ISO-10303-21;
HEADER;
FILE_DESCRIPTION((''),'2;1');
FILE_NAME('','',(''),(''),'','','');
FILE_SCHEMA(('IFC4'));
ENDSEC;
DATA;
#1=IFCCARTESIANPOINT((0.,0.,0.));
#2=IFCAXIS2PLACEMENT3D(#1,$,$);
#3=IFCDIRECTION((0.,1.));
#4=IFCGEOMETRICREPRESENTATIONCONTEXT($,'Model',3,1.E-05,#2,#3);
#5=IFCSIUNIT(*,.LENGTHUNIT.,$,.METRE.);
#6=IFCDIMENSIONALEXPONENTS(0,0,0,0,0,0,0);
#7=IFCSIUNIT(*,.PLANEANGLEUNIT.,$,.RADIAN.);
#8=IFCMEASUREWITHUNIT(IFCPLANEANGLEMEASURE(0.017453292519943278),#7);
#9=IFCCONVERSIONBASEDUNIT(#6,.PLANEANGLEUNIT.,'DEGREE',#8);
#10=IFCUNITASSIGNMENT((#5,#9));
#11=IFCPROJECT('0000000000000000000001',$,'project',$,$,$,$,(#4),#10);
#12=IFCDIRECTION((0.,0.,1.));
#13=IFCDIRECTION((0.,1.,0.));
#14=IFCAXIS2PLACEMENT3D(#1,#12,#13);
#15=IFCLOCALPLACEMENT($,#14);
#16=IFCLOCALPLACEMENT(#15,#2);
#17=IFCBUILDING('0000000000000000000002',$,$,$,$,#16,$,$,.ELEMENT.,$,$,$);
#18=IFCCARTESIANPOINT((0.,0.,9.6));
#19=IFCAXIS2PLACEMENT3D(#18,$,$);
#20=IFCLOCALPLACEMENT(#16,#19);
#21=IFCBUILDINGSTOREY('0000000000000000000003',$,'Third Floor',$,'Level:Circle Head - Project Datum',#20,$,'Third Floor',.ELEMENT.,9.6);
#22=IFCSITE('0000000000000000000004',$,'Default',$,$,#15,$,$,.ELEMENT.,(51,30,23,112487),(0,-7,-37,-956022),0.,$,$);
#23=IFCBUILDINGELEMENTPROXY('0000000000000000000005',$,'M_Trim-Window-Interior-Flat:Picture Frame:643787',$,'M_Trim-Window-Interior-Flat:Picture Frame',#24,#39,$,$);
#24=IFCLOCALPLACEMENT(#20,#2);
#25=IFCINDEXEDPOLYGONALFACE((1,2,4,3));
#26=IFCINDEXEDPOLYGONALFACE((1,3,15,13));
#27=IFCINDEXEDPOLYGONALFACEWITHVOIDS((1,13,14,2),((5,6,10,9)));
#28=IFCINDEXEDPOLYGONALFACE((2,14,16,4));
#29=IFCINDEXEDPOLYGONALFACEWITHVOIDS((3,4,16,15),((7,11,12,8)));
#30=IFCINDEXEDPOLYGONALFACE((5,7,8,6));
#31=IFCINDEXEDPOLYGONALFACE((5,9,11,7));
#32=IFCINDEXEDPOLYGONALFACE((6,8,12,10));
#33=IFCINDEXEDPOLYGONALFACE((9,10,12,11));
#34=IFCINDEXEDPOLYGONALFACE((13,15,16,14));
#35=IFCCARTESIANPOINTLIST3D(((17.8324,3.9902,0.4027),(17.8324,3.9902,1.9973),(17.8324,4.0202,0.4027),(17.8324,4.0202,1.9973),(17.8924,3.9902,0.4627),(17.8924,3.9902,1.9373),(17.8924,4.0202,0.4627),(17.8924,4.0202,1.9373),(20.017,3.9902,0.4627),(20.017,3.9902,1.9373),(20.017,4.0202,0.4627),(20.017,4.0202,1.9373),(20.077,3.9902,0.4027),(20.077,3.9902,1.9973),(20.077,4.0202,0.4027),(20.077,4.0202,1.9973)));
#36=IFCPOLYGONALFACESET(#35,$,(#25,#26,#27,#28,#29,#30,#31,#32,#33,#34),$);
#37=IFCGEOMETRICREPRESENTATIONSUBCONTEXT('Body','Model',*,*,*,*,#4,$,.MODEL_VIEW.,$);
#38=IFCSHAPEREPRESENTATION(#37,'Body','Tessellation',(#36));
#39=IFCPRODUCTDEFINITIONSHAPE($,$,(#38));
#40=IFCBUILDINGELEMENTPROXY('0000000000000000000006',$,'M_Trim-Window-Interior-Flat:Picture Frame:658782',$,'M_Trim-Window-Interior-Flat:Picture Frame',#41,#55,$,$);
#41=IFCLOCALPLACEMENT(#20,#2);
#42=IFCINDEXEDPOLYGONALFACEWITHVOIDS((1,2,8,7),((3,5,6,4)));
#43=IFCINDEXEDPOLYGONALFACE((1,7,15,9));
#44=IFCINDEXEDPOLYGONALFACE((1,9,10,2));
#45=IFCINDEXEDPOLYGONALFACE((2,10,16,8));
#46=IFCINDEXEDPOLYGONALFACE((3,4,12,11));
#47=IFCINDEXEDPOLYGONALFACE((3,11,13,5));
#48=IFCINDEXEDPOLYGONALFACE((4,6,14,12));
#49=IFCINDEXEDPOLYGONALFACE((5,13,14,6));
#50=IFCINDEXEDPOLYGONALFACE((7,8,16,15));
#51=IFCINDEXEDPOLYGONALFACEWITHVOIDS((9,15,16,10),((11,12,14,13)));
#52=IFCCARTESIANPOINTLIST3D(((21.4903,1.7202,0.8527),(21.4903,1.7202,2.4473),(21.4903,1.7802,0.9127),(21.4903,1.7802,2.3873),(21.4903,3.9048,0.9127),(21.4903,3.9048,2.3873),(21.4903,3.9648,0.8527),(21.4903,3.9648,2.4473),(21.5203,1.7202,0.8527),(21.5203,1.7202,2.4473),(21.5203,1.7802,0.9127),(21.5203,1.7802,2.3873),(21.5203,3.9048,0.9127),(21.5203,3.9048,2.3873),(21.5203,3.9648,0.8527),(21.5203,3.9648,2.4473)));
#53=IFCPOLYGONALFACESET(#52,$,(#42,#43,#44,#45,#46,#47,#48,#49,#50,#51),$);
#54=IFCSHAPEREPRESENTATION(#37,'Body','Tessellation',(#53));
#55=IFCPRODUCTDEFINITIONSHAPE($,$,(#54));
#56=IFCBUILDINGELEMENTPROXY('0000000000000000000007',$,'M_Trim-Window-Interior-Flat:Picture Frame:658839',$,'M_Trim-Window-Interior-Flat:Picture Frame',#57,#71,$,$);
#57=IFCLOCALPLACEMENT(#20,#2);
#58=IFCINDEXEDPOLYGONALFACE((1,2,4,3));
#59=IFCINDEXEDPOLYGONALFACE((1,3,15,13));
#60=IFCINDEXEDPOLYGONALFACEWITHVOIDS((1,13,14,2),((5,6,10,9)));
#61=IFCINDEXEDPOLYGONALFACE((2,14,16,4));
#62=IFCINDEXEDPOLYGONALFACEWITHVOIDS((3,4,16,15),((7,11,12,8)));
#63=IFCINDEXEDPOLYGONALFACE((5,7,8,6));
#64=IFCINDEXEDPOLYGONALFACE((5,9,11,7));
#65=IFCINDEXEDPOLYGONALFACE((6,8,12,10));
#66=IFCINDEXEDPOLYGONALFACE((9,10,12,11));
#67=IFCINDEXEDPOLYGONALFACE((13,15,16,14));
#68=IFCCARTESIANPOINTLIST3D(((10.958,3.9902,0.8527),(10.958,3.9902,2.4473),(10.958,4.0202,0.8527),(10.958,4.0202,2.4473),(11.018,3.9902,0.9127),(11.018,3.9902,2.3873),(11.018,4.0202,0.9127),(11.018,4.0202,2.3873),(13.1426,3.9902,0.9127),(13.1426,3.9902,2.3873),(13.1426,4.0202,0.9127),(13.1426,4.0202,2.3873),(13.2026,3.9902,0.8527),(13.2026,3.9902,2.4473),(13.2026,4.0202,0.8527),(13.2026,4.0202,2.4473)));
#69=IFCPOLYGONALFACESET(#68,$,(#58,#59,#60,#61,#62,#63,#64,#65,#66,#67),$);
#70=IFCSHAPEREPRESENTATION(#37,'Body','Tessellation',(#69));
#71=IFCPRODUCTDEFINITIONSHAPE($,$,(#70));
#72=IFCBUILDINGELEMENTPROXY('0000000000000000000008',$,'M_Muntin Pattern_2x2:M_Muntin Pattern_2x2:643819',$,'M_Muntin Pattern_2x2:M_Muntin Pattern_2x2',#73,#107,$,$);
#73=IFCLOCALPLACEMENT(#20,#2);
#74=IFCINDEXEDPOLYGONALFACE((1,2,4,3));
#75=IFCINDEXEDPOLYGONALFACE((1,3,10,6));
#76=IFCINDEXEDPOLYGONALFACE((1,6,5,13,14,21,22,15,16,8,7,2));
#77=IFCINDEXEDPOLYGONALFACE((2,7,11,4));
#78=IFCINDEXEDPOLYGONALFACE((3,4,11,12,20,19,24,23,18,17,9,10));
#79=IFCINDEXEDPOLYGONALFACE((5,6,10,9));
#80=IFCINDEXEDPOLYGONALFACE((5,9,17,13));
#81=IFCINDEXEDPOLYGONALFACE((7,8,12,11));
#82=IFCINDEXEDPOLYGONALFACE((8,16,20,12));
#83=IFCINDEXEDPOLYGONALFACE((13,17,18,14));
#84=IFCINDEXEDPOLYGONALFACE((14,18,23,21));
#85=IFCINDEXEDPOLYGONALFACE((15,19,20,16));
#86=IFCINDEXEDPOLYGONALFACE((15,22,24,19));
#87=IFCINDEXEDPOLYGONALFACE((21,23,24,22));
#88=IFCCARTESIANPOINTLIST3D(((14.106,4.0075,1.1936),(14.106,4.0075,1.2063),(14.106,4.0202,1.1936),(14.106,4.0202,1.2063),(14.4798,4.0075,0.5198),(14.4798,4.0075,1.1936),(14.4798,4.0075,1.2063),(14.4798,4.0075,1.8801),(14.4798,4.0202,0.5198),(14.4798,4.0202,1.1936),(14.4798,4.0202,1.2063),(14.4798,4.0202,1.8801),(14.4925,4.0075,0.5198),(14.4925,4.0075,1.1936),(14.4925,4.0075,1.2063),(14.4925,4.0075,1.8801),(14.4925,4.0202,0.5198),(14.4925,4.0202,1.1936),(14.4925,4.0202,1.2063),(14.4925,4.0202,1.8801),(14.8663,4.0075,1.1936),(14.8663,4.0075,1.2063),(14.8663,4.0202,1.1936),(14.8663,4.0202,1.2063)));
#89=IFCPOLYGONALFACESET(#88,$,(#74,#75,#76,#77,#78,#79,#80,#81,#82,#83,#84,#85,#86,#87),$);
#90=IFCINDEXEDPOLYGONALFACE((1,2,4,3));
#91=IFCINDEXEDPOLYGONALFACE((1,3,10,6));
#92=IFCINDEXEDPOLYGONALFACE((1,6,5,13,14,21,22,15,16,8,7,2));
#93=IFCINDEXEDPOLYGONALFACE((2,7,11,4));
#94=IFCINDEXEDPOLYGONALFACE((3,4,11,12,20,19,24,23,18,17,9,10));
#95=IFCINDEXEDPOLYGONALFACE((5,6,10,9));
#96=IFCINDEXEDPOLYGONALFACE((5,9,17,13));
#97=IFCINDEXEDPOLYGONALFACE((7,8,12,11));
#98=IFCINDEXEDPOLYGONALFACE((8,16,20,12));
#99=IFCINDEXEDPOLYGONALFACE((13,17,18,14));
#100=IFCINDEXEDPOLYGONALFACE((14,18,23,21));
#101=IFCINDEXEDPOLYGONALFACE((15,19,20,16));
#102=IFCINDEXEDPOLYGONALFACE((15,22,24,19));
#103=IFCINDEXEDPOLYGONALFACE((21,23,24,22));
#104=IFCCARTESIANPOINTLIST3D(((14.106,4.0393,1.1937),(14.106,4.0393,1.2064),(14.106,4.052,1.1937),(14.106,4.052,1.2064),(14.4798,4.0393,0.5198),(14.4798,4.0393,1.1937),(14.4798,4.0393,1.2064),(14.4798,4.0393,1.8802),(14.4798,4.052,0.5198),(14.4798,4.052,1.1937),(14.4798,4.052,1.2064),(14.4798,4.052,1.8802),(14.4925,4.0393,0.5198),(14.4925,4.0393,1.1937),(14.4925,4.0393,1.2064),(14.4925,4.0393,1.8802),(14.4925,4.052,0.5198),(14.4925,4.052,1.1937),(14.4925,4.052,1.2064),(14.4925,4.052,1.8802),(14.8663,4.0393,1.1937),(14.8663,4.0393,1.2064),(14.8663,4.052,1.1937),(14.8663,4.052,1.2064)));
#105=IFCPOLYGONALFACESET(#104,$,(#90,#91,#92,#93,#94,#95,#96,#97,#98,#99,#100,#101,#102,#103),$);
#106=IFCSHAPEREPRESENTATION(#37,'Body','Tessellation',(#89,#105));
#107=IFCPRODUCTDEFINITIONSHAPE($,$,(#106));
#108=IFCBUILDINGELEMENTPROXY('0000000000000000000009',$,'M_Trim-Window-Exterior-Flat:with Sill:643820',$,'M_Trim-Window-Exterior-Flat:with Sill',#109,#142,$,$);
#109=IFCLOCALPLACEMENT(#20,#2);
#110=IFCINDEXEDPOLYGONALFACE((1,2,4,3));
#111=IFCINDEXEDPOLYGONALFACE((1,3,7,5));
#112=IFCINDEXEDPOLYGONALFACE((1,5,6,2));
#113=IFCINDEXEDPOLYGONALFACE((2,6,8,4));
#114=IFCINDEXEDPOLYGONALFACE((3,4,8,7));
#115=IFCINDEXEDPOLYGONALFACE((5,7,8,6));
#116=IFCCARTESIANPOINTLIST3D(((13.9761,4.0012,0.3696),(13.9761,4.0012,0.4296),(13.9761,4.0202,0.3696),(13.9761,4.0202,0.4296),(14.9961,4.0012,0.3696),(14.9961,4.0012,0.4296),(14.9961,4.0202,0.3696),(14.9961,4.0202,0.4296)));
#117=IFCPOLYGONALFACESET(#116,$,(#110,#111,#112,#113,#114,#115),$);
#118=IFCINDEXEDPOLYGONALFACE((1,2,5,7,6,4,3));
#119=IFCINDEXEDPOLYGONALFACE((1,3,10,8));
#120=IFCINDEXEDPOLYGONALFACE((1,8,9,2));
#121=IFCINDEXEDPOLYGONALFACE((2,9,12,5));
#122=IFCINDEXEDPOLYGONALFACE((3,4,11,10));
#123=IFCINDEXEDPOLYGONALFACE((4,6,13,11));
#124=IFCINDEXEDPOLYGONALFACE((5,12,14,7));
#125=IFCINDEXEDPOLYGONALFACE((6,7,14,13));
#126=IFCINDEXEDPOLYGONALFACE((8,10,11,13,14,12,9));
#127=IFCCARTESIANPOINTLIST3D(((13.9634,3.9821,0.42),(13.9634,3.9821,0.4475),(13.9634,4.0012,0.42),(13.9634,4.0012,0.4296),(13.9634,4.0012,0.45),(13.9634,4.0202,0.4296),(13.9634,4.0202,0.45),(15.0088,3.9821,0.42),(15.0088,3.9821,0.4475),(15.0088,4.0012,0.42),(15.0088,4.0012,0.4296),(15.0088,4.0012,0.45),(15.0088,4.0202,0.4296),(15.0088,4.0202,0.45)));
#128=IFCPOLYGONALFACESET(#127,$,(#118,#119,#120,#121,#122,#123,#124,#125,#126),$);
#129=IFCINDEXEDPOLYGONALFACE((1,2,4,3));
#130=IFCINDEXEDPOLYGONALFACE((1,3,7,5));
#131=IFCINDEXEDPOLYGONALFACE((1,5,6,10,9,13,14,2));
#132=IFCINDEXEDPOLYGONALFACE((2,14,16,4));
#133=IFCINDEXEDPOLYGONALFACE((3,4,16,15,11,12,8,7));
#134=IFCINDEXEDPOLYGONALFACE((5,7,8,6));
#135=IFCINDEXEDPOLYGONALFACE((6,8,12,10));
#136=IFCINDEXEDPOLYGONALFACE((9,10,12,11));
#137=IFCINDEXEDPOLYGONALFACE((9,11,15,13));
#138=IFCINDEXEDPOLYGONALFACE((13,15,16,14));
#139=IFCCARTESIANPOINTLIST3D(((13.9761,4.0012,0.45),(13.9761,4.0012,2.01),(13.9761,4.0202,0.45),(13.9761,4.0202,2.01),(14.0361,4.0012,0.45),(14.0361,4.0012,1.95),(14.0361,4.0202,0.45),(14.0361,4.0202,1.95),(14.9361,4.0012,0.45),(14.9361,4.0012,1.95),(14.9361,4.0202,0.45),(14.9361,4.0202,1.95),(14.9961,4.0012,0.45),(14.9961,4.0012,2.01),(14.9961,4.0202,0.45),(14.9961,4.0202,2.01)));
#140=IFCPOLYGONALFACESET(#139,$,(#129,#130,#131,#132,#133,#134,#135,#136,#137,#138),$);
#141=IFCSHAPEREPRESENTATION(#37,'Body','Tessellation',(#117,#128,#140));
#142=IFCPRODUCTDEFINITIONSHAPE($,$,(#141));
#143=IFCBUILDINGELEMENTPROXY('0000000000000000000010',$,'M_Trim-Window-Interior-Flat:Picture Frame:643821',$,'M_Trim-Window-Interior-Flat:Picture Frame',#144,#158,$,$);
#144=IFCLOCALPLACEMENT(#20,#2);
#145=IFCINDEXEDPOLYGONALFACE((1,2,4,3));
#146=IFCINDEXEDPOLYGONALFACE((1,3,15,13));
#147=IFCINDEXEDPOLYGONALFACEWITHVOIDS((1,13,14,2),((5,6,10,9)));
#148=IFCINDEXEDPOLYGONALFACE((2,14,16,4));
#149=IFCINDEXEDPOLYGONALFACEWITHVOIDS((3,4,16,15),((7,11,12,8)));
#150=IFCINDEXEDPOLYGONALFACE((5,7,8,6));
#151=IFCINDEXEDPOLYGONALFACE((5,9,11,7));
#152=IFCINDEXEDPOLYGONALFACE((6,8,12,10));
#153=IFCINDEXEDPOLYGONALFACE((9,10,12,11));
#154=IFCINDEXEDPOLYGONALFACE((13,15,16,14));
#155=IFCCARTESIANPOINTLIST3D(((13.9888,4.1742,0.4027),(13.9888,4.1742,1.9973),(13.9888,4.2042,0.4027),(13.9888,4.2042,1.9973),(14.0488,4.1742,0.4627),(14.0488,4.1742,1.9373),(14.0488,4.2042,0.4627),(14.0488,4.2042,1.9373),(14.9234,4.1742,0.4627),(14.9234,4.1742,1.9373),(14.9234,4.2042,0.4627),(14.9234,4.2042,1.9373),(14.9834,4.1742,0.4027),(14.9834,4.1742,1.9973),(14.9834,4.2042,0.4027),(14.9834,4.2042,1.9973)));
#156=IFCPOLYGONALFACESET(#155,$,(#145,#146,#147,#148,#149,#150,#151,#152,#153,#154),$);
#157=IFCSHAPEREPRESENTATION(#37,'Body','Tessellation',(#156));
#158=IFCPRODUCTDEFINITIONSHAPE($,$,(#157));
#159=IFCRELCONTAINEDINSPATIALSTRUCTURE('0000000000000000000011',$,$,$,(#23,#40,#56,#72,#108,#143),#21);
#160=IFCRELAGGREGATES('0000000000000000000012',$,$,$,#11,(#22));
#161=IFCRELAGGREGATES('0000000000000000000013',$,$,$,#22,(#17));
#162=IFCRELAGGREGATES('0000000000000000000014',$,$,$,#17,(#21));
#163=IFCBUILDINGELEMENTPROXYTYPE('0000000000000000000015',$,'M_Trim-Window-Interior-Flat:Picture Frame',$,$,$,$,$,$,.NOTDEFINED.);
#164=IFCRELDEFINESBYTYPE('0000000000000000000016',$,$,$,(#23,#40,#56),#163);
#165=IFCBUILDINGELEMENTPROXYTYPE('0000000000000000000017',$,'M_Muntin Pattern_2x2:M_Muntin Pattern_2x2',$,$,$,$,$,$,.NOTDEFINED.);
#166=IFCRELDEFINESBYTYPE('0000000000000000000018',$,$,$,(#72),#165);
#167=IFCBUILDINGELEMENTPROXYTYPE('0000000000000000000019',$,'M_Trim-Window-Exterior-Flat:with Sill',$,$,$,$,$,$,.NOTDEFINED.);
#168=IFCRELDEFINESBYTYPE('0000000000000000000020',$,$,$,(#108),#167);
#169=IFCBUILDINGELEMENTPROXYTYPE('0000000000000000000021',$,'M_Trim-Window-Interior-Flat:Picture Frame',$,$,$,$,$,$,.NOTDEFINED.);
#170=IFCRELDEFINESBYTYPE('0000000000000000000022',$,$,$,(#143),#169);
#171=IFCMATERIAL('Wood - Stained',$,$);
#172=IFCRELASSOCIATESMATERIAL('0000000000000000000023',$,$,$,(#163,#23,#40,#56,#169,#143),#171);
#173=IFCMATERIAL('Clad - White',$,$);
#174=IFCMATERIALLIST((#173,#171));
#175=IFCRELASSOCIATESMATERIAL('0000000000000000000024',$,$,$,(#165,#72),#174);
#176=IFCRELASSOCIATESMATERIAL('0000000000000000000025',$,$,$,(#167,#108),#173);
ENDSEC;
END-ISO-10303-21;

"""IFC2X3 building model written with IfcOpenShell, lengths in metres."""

from ifc_helpers import new_model, entity, si_unit, converted_unit, direction, frame, frame_2d, origin, place, context, subcontext, project, spatial, polyline, rectangle, outline, extrude, source, transform, mapped, material, material_list, type_object, type_shapes, element, save


model = new_model("IFC2X3")

# Units and contexts
model_context = context("Model", 3, precision=1e-05, world=origin(), true_north=direction((0.0, 1.0)))
body_context = subcontext(model_context, "Body", "Model", "MODEL_VIEW")
ifc_project = project(units=[si_unit("LENGTHUNIT", "METRE"), converted_unit("PLANEANGLEUNIT", "DEGREE", entity("IfcPlaneAngleMeasure", 0.017453292519943278), si_unit("PLANEANGLEUNIT", "RADIAN"), dimensions=[0, 0, 0, 0, 0, 0, 0])], contexts=[model_context])

# Site, building, storey
site_placement = place(None, frame((0.0, 0.0, 0.0), z_axis=(0.0, 0.0, 1.0), x_axis=(0.0, 1.0, 0.0)))
site = spatial("IfcSite", under=ifc_project, at=site_placement, Name="Default", CompositionType="ELEMENT", RefLatitude=(51, 30, 23, 112487), RefLongitude=(0, -7, -37, -956022), RefElevation=0.0)
building_placement = place(site_placement, origin())
building = spatial("IfcBuilding", under=site, at=building_placement, CompositionType="ELEMENT")
storey_placement = place(building_placement, frame((0.0, 0.0, 9.6)))
storey = spatial("IfcBuildingStorey", under=building, at=storey_placement, Name="Third Floor", ObjectType="Level:Circle Head - Project Datum", LongName="Third Floor", CompositionType="ELEMENT", Elevation=9.6)

# Building element proxies
ifc_material_1 = material(Name="Clad - White")
ifc_material_2 = material(Name="Wood - Stained")
ifc_material_list = material_list([ifc_material_1, ifc_material_2])
building_element_proxy_type_1 = type_object("IfcBuildingElementProxyType", Name="M_Trim-Window-Interior-Flat:Picture Frame", PredefinedType="NOTDEFINED", material=ifc_material_2)
shared_shape_1 = source(origin(), body_context, "Body", "SweptSolid", [
    extrude(outline(polyline([(-1.1223, -0.7973), (1.1223, -0.7973), (1.1223, 0.7973), (-1.1223, 0.7973), (-1.1223, -0.7973)]), holes=[polyline([(-1.0623, -0.7373), (-1.0623, 0.7373), (1.0623, 0.7373), (1.0623, -0.7373), (-1.0623, -0.7373)])]), frame((0.0, -0.75, 0.0), z_axis=(0.0, 0.0, 1.0), x_axis=(-1.0, 0.0, 0.0)), (0.0, 0.0, 1.0), 0.03),
])
type_shapes(building_element_proxy_type_1, [shared_shape_1])
for number, where, z_axis, x_axis, name in (
    (1, (18.9547, 4.0202, 1.95), (0.0, -1.0, 0.0), (1.0, 0.0, 0.0), "M_Trim-Window-Interior-Flat:Picture Frame:643787"),
    (2, (21.5203, 2.8425, 2.4), (-1.0, 0.0, 0.0), (0.0, -1.0, 0.0), "M_Trim-Window-Interior-Flat:Picture Frame:658782"),
    (3, (12.0803, 4.0202, 2.4), (0.0, -1.0, 0.0), (1.0, 0.0, 0.0), "M_Trim-Window-Interior-Flat:Picture Frame:658839"),
):
    element("IfcBuildingElementProxy", number, at=place(storey_placement, frame(where, z_axis=z_axis, x_axis=x_axis)), inside=storey, type_object=building_element_proxy_type_1, material=ifc_material_2, Name=name, ObjectType="M_Trim-Window-Interior-Flat:Picture Frame", context=body_context, shape_type="MappedRepresentation", body=[
        mapped(shared_shape_1, transform((0.0, 0.0, 0.0), scale=1.0)),
    ])
building_element_proxy_type_2 = type_object("IfcBuildingElementProxyType", Name="M_Muntin Pattern_2x2:M_Muntin Pattern_2x2", PredefinedType="NOTDEFINED", material=ifc_material_list)
shared_shape_2 = source(origin(), body_context, "Body", "SweptSolid", [
    extrude(outline(polyline([(0.0064, -0.0064), (0.6801, -0.0064), (0.6801, 0.0063), (0.0064, 0.0063), (0.0064, 0.3802), (-0.0063, 0.3802), (-0.0063, 0.0063), (-0.6802, 0.0063), (-0.6802, -0.0064), (-0.0063, -0.0064), (-0.0063, -0.3801), (0.0064, -0.3801), (0.0064, -0.0064)])), frame((0.0, 0.0095, 0.6801), z_axis=(0.0, 1.0, 0.0), x_axis=(0.0, 0.0, 1.0)), (0.0, 0.0, 1.0), 0.0127),
    extrude(outline(polyline([(0.0064, -0.0064), (0.6802, -0.0064), (0.6802, 0.0063), (0.0064, 0.0063), (0.0064, 0.3802), (-0.0063, 0.3802), (-0.0063, 0.0063), (-0.6802, 0.0063), (-0.6802, -0.0064), (-0.0063, -0.0064), (-0.0063, -0.3801), (0.0064, -0.3801), (0.0064, -0.0064)])), frame((0.0, -0.0222, 0.6802), z_axis=(0.0, 1.0, 0.0), x_axis=(0.0, 0.0, 1.0)), (0.0, 0.0, 1.0), 0.0127),
])
type_shapes(building_element_proxy_type_2, [shared_shape_2])
proxy_1_placement = place(storey_placement, frame((14.4861, 4.0298, 0.5198), z_axis=(0.0, 0.0, 1.0), x_axis=(-1.0, 0.0, 0.0)))
element("IfcBuildingElementProxy", 4, at=proxy_1_placement, inside=storey, type_object=building_element_proxy_type_2, material=ifc_material_list, Name="M_Muntin Pattern_2x2:M_Muntin Pattern_2x2:643819", ObjectType="M_Muntin Pattern_2x2:M_Muntin Pattern_2x2", context=body_context, shape_type="MappedRepresentation", body=[
    mapped(shared_shape_2, transform((0.0, 0.0, 0.0), scale=1.0)),
])
building_element_proxy_type_3 = type_object("IfcBuildingElementProxyType", Name="M_Trim-Window-Exterior-Flat:with Sill", PredefinedType="NOTDEFINED", material=ifc_material_1)
shared_shape_3 = source(origin(), body_context, "Body", "SweptSolid", [
    extrude(rectangle(XDim=1.02, YDim=0.06, at=frame_2d((0.0, 0.0), x_axis=(1.0, 0.0))), frame((0.0, -1.5504, 0.0), z_axis=(0.0, 0.0, 1.0), x_axis=(-1.0, 0.0, 0.0)), (0.0, 0.0, 1.0), 0.019),
    extrude(outline(polyline([(-0.019, -0.0152), (0.0, -0.0152), (0.0, -0.0057), (0.019, -0.0057), (0.019, 0.0148), (0.0, 0.0148), (-0.019, 0.0123), (-0.019, -0.0152)])), frame((-0.5227, -1.5148, 0.019), z_axis=(1.0, 0.0, 0.0), x_axis=(0.0, 0.0, -1.0)), (0.0, 0.0, 1.0), 1.0454),
    extrude(outline(polyline([(-0.795, -0.51), (0.765, -0.51), (0.765, -0.45), (-0.735, -0.45), (-0.735, 0.45), (0.765, 0.45), (0.765, 0.51), (-0.795, 0.51), (-0.795, -0.51)])), frame((0.0, -0.735, 0.0), z_axis=(0.0, 0.0, 1.0), x_axis=(0.0, -1.0, 0.0)), (0.0, 0.0, 1.0), 0.019),
])
type_shapes(building_element_proxy_type_3, [shared_shape_3])
proxy_2_placement = place(storey_placement, frame((14.4861, 4.0202, 1.95), z_axis=(0.0, -1.0, 0.0), x_axis=(1.0, 0.0, 0.0)))
element("IfcBuildingElementProxy", 5, at=proxy_2_placement, inside=storey, type_object=building_element_proxy_type_3, material=ifc_material_1, Name="M_Trim-Window-Exterior-Flat:with Sill:643820", ObjectType="M_Trim-Window-Exterior-Flat:with Sill", context=body_context, shape_type="MappedRepresentation", body=[
    mapped(shared_shape_3, transform((0.0, 0.0, 0.0), scale=1.0)),
])
building_element_proxy_type_4 = type_object("IfcBuildingElementProxyType", Name="M_Trim-Window-Interior-Flat:Picture Frame", PredefinedType="NOTDEFINED", material=ifc_material_2)
shared_shape_4 = source(origin(), body_context, "Body", "SweptSolid", [
    extrude(outline(polyline([(-0.4973, -0.7973), (0.4973, -0.7973), (0.4973, 0.7973), (-0.4973, 0.7973), (-0.4973, -0.7973)]), holes=[polyline([(-0.4373, -0.7373), (-0.4373, 0.7373), (0.4373, 0.7373), (0.4373, -0.7373), (-0.4373, -0.7373)])]), frame((0.0, -0.75, 0.0), z_axis=(0.0, 0.0, 1.0), x_axis=(-1.0, 0.0, 0.0)), (0.0, 0.0, 1.0), 0.03),
])
type_shapes(building_element_proxy_type_4, [shared_shape_4])
proxy_3_placement = place(storey_placement, frame((14.4861, 4.1742, 1.95), z_axis=(0.0, 1.0, 0.0), x_axis=(-1.0, 0.0, 0.0)))
element("IfcBuildingElementProxy", 6, at=proxy_3_placement, inside=storey, type_object=building_element_proxy_type_4, material=ifc_material_2, Name="M_Trim-Window-Interior-Flat:Picture Frame:643821", ObjectType="M_Trim-Window-Interior-Flat:Picture Frame", context=body_context, shape_type="MappedRepresentation", body=[
    mapped(shared_shape_4, transform((0.0, 0.0, 0.0), scale=1.0)),
])

save(model, "model.ifc")
